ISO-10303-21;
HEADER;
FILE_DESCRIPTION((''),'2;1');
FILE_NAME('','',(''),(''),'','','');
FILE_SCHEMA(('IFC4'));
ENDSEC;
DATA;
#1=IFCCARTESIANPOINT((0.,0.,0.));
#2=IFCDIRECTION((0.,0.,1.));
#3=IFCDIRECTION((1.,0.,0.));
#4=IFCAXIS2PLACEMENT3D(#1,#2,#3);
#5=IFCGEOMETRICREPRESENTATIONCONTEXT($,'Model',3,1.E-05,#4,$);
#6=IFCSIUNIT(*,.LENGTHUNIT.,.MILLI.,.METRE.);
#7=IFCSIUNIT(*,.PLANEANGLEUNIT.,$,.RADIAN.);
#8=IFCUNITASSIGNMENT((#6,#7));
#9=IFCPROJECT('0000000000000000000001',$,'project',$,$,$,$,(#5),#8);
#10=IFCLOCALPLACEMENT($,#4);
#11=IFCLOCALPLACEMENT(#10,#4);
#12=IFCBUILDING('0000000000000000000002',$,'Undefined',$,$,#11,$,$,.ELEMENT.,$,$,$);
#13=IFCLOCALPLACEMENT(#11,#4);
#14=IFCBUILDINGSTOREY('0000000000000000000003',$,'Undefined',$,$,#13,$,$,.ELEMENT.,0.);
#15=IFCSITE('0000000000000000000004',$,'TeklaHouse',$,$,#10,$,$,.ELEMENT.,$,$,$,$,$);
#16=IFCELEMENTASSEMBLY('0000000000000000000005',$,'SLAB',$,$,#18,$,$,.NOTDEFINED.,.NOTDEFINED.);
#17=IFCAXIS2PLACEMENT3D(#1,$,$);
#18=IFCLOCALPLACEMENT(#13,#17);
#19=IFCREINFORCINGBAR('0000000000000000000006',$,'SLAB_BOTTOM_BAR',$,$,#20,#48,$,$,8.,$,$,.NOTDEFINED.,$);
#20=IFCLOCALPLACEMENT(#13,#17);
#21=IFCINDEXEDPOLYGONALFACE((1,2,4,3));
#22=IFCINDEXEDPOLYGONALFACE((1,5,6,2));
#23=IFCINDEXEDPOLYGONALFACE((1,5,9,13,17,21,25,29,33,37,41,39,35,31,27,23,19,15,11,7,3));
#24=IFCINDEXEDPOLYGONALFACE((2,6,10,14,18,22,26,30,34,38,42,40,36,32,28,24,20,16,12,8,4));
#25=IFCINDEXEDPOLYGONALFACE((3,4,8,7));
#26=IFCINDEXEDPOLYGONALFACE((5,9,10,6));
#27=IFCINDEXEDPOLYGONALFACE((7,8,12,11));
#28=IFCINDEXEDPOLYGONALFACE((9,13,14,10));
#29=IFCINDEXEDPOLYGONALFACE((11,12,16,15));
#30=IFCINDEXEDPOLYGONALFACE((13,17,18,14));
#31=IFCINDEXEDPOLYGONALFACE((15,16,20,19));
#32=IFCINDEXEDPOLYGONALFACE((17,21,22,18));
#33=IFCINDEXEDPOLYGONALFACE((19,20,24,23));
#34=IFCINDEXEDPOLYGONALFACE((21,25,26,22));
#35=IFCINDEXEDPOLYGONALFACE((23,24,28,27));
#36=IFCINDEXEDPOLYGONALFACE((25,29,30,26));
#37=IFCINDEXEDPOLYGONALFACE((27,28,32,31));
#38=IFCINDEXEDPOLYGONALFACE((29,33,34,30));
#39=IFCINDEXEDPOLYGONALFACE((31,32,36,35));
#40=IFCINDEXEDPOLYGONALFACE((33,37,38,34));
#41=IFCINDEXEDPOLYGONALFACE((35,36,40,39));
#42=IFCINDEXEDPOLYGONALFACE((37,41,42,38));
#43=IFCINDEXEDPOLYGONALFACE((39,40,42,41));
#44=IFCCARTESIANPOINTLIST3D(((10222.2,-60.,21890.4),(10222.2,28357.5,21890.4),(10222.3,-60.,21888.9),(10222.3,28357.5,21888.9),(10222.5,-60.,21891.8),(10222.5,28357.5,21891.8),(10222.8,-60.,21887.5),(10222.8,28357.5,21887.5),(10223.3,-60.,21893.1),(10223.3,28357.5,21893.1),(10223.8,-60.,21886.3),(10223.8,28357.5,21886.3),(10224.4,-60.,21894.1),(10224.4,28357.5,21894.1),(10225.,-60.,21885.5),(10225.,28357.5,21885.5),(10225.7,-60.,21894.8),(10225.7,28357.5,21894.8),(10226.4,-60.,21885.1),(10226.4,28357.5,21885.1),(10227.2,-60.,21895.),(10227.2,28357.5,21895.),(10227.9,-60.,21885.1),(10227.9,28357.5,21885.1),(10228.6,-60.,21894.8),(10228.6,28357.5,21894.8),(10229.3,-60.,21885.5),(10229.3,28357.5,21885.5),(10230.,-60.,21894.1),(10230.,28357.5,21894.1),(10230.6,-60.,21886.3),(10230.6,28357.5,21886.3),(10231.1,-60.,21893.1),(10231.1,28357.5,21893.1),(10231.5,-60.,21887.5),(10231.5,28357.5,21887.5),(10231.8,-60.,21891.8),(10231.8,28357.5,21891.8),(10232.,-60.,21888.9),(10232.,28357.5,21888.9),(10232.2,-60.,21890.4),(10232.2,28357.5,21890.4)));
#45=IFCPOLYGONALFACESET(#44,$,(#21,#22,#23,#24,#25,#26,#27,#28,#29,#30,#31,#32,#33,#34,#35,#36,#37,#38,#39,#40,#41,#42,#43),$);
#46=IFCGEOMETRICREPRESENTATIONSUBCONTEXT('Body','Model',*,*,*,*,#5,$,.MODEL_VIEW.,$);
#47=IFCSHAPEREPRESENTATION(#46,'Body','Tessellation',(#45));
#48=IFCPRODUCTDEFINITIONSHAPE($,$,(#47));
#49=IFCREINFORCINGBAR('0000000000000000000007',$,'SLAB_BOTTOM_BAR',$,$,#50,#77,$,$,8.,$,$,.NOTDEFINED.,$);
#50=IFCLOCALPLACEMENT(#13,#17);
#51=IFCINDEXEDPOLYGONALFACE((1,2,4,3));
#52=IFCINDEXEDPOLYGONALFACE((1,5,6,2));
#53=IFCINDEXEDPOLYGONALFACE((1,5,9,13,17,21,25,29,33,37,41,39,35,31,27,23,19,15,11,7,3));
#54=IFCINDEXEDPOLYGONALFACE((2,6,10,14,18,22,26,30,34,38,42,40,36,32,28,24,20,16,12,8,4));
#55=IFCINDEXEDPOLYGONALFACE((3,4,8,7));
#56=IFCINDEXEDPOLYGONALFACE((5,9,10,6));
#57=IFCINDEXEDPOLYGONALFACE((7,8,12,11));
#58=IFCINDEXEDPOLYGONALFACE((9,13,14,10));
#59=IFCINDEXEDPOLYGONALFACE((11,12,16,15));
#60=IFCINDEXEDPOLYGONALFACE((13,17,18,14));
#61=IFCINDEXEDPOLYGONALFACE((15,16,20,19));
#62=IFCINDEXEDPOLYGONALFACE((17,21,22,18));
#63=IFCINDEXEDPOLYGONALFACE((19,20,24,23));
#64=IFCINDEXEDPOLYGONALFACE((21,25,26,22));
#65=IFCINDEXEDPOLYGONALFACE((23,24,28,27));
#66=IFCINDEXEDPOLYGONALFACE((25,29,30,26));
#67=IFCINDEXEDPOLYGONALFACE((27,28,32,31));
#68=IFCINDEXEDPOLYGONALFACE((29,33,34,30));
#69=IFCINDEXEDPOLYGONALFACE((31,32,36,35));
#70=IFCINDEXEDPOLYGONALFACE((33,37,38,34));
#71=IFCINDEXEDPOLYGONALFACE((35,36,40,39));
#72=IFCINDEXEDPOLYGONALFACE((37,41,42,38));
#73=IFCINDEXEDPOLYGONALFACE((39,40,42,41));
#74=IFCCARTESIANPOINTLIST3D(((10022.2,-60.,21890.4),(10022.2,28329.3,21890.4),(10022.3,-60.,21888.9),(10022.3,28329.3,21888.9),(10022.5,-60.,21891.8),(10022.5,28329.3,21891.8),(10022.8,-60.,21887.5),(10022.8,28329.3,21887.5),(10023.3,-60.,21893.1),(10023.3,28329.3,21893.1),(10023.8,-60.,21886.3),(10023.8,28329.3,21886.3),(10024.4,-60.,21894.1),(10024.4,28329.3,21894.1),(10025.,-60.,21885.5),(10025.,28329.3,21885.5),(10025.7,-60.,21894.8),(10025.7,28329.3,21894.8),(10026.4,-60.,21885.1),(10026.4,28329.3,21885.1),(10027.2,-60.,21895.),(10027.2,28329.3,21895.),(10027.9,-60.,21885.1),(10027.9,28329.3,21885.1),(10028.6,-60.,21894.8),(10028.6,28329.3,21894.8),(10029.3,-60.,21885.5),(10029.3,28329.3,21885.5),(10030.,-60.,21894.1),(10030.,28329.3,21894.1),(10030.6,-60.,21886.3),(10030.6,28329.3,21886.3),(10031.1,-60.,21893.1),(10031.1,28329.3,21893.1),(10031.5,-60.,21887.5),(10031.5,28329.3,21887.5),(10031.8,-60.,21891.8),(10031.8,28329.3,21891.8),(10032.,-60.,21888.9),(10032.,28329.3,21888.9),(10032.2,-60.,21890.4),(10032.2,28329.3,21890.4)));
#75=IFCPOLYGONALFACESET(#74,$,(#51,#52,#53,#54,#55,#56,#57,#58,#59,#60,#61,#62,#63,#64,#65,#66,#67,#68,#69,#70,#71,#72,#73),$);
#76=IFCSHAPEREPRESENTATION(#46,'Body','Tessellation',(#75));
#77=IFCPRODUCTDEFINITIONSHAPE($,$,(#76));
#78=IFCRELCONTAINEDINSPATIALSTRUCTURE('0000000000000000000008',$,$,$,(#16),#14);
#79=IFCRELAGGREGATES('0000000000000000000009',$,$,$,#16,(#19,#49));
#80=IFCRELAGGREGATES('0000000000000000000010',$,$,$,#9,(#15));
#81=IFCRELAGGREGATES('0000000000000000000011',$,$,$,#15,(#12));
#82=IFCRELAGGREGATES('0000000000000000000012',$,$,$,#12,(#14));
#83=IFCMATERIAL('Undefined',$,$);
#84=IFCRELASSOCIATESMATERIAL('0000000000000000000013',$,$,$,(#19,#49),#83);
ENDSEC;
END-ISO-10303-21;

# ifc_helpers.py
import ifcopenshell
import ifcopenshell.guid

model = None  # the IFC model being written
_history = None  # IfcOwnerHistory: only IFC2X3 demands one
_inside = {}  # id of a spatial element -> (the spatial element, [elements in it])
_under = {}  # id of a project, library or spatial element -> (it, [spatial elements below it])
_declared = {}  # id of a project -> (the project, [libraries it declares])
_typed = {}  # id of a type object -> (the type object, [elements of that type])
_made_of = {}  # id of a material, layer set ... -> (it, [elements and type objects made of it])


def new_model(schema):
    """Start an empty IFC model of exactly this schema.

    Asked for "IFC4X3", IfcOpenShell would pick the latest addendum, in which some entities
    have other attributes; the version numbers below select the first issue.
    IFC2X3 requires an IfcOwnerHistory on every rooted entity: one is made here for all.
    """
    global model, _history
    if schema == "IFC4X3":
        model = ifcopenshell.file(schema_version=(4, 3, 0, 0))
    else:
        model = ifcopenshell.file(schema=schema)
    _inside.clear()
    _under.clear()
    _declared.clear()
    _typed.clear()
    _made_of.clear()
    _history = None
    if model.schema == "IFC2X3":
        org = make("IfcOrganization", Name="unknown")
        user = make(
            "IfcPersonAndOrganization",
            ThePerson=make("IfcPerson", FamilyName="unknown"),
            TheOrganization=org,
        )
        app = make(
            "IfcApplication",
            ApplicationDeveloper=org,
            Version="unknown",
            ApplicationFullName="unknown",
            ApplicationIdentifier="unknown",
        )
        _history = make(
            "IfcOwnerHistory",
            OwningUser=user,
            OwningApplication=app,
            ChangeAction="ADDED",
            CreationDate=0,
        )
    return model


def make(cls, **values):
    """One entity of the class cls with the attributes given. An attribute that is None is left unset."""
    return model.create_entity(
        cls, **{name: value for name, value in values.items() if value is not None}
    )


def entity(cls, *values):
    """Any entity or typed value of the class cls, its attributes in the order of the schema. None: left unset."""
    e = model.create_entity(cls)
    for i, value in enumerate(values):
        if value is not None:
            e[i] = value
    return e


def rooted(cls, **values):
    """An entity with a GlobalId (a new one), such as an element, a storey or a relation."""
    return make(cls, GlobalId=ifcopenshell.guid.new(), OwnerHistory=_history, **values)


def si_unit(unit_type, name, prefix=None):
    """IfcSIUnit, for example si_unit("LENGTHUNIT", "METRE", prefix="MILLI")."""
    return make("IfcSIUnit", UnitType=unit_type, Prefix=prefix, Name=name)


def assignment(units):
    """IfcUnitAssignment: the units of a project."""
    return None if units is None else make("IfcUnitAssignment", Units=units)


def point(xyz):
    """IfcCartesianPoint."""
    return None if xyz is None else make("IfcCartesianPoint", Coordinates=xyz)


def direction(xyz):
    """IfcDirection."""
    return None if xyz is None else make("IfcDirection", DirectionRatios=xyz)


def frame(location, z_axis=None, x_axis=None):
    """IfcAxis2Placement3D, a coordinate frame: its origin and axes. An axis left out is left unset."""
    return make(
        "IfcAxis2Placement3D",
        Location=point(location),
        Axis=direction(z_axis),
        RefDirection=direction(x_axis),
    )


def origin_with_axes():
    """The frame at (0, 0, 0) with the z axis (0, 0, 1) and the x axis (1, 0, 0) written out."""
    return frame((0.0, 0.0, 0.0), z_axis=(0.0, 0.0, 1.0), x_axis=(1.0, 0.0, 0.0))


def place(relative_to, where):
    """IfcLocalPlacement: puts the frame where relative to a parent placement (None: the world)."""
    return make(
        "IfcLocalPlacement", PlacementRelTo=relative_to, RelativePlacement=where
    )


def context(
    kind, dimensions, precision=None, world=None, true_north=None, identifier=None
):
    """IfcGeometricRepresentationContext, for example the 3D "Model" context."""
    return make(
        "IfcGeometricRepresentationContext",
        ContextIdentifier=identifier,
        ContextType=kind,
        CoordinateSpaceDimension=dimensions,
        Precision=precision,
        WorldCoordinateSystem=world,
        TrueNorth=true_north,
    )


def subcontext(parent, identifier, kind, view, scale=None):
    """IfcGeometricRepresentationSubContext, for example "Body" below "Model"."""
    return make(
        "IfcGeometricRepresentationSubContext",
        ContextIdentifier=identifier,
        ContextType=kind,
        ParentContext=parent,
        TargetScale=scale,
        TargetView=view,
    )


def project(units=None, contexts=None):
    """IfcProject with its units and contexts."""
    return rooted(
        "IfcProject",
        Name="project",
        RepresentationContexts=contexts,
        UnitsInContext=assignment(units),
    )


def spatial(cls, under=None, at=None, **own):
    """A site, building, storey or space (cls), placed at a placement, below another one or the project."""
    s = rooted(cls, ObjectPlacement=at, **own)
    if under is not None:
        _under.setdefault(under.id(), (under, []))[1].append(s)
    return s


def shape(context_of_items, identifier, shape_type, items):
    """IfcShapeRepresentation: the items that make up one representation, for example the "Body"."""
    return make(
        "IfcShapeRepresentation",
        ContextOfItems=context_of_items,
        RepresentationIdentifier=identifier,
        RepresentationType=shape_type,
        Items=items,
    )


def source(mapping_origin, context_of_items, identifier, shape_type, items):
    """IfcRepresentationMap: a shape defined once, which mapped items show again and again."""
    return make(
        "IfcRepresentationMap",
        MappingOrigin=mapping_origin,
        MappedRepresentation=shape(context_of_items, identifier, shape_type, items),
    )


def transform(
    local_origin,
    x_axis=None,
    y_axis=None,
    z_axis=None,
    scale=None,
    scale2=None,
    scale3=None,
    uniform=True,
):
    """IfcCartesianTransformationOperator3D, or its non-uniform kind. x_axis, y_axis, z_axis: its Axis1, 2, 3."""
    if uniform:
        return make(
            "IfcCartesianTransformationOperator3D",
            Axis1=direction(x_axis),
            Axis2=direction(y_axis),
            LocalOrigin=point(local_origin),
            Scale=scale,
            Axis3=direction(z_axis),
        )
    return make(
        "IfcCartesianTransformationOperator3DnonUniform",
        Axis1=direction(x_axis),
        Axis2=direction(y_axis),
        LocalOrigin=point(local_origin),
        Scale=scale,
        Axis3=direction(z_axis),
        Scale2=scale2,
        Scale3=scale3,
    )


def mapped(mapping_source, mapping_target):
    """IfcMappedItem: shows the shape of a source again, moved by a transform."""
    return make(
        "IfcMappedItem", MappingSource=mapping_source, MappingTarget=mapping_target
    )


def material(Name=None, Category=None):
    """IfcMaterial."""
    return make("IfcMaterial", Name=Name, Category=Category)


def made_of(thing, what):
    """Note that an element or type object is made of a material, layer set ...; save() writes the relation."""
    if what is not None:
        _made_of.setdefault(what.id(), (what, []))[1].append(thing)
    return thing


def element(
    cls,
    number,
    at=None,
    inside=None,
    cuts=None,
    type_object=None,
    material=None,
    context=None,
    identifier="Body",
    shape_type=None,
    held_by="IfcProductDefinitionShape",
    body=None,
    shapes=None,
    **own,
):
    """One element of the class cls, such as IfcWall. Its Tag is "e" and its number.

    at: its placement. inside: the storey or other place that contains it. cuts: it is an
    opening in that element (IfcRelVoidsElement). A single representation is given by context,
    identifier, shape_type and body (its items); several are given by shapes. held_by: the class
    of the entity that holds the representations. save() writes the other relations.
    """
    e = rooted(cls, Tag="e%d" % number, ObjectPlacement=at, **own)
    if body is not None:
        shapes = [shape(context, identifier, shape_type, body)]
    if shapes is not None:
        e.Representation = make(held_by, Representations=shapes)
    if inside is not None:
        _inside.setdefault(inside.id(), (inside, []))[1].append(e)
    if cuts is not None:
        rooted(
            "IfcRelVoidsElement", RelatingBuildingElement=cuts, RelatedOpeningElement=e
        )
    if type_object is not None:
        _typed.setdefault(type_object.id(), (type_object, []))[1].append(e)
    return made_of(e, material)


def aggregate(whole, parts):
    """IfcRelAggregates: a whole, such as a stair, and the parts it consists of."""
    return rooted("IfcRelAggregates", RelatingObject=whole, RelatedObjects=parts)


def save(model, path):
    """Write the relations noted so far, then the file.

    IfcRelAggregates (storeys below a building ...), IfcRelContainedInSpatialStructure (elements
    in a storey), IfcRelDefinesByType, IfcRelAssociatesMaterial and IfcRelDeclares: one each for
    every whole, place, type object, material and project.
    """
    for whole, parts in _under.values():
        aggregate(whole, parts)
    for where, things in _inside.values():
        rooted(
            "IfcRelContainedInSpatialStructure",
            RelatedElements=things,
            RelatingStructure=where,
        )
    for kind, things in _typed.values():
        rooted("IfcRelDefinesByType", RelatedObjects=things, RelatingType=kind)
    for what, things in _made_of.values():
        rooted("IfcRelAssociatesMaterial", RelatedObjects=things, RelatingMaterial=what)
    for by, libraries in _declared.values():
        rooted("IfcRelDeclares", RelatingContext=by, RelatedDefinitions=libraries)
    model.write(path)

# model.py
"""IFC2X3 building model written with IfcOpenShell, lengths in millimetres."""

from ifc_helpers import new_model, entity, si_unit, frame, origin_with_axes, place, context, subcontext, project, spatial, source, transform, mapped, material, element, aggregate, save


model = new_model("IFC2X3")

# Units and contexts
model_context = context("Model", 3, precision=1e-05, world=origin_with_axes())
body_context = subcontext(model_context, "Body", "Model", "MODEL_VIEW")
ifc_project = project(units=[si_unit("LENGTHUNIT", "METRE", prefix="MILLI"), si_unit("PLANEANGLEUNIT", "RADIAN")], contexts=[model_context])

# Site, building, storey
site_placement = place(None, origin_with_axes())
site = spatial("IfcSite", under=ifc_project, at=site_placement, Name="TeklaHouse", CompositionType="ELEMENT")
building_placement = place(site_placement, origin_with_axes())
building = spatial("IfcBuilding", under=site, at=building_placement, Name="Undefined", CompositionType="ELEMENT")
storey_placement = place(building_placement, origin_with_axes())
storey = spatial("IfcBuildingStorey", under=building, at=storey_placement, Name="Undefined", CompositionType="ELEMENT", Elevation=0.0)

# Shared definitions
ifc_material_1 = material(Name="Undefined")

# Element assembly, reinforcing bars
assembly_1_placement = place(storey_placement, origin_with_axes())
assembly_1 = element("IfcElementAssembly", 1, at=assembly_1_placement, inside=storey, Name="SLAB", AssemblyPlace="NOTDEFINED", PredefinedType="NOTDEFINED")
shared_shape_1 = source(origin_with_axes(), body_context, "Body", "AdvancedSweptSolid", [
    entity("IfcSweptDiskSolid", entity("IfcTrimmedCurve", entity("IfcLine", entity("IfcCartesianPoint", [0.0, 0.0, 0.0]), entity("IfcVector", entity("IfcDirection", [1.0, 0.0, 0.0]), 1.0)), [entity("IfcParameterValue", 0.0)], [entity("IfcParameterValue", 28417.521145)], True, "PARAMETER"), 5.0, None, 0.0, 28417.5),
])
reinforcing_bar_1_placement = place(assembly_1_placement, frame((10227.2, -60.0, 21890.0), z_axis=(0.0, 0.0, 1.0), x_axis=(0.0, 1.0, 0.0)))
reinforcing_bar_1 = element("IfcReinforcingBar", 2, at=reinforcing_bar_1_placement, material=ifc_material_1, Name="SLAB_BOTTOM_BAR", BarRole="NOTDEFINED", NominalDiameter=8.0, context=body_context, shape_type="MappedRepresentation", body=[
    mapped(shared_shape_1, transform((0.0, 0.0, 0.0))),
])
shared_shape_2 = source(origin_with_axes(), body_context, "Body", "AdvancedSweptSolid", [
    entity("IfcSweptDiskSolid", entity("IfcTrimmedCurve", entity("IfcLine", entity("IfcCartesianPoint", [0.0, 0.0, 0.0]), entity("IfcVector", entity("IfcDirection", [1.0, 0.0, 0.0]), 1.0)), [entity("IfcParameterValue", 0.0)], [entity("IfcParameterValue", 28389.279034)], True, "PARAMETER"), 5.0, None, 0.0, 28389.3),
])
reinforcing_bar_2_placement = place(assembly_1_placement, frame((10027.2, -60.0, 21890.0), z_axis=(0.0, 0.0, 1.0), x_axis=(0.0, 1.0, 0.0)))
reinforcing_bar_2 = element("IfcReinforcingBar", 3, at=reinforcing_bar_2_placement, material=ifc_material_1, Name="SLAB_BOTTOM_BAR", BarRole="NOTDEFINED", NominalDiameter=8.0, context=body_context, shape_type="MappedRepresentation", body=[
    mapped(shared_shape_2, transform((0.0, 0.0, 0.0))),
])
aggregate(assembly_1, [reinforcing_bar_1, reinforcing_bar_2])

save(model, "model.ifc")
